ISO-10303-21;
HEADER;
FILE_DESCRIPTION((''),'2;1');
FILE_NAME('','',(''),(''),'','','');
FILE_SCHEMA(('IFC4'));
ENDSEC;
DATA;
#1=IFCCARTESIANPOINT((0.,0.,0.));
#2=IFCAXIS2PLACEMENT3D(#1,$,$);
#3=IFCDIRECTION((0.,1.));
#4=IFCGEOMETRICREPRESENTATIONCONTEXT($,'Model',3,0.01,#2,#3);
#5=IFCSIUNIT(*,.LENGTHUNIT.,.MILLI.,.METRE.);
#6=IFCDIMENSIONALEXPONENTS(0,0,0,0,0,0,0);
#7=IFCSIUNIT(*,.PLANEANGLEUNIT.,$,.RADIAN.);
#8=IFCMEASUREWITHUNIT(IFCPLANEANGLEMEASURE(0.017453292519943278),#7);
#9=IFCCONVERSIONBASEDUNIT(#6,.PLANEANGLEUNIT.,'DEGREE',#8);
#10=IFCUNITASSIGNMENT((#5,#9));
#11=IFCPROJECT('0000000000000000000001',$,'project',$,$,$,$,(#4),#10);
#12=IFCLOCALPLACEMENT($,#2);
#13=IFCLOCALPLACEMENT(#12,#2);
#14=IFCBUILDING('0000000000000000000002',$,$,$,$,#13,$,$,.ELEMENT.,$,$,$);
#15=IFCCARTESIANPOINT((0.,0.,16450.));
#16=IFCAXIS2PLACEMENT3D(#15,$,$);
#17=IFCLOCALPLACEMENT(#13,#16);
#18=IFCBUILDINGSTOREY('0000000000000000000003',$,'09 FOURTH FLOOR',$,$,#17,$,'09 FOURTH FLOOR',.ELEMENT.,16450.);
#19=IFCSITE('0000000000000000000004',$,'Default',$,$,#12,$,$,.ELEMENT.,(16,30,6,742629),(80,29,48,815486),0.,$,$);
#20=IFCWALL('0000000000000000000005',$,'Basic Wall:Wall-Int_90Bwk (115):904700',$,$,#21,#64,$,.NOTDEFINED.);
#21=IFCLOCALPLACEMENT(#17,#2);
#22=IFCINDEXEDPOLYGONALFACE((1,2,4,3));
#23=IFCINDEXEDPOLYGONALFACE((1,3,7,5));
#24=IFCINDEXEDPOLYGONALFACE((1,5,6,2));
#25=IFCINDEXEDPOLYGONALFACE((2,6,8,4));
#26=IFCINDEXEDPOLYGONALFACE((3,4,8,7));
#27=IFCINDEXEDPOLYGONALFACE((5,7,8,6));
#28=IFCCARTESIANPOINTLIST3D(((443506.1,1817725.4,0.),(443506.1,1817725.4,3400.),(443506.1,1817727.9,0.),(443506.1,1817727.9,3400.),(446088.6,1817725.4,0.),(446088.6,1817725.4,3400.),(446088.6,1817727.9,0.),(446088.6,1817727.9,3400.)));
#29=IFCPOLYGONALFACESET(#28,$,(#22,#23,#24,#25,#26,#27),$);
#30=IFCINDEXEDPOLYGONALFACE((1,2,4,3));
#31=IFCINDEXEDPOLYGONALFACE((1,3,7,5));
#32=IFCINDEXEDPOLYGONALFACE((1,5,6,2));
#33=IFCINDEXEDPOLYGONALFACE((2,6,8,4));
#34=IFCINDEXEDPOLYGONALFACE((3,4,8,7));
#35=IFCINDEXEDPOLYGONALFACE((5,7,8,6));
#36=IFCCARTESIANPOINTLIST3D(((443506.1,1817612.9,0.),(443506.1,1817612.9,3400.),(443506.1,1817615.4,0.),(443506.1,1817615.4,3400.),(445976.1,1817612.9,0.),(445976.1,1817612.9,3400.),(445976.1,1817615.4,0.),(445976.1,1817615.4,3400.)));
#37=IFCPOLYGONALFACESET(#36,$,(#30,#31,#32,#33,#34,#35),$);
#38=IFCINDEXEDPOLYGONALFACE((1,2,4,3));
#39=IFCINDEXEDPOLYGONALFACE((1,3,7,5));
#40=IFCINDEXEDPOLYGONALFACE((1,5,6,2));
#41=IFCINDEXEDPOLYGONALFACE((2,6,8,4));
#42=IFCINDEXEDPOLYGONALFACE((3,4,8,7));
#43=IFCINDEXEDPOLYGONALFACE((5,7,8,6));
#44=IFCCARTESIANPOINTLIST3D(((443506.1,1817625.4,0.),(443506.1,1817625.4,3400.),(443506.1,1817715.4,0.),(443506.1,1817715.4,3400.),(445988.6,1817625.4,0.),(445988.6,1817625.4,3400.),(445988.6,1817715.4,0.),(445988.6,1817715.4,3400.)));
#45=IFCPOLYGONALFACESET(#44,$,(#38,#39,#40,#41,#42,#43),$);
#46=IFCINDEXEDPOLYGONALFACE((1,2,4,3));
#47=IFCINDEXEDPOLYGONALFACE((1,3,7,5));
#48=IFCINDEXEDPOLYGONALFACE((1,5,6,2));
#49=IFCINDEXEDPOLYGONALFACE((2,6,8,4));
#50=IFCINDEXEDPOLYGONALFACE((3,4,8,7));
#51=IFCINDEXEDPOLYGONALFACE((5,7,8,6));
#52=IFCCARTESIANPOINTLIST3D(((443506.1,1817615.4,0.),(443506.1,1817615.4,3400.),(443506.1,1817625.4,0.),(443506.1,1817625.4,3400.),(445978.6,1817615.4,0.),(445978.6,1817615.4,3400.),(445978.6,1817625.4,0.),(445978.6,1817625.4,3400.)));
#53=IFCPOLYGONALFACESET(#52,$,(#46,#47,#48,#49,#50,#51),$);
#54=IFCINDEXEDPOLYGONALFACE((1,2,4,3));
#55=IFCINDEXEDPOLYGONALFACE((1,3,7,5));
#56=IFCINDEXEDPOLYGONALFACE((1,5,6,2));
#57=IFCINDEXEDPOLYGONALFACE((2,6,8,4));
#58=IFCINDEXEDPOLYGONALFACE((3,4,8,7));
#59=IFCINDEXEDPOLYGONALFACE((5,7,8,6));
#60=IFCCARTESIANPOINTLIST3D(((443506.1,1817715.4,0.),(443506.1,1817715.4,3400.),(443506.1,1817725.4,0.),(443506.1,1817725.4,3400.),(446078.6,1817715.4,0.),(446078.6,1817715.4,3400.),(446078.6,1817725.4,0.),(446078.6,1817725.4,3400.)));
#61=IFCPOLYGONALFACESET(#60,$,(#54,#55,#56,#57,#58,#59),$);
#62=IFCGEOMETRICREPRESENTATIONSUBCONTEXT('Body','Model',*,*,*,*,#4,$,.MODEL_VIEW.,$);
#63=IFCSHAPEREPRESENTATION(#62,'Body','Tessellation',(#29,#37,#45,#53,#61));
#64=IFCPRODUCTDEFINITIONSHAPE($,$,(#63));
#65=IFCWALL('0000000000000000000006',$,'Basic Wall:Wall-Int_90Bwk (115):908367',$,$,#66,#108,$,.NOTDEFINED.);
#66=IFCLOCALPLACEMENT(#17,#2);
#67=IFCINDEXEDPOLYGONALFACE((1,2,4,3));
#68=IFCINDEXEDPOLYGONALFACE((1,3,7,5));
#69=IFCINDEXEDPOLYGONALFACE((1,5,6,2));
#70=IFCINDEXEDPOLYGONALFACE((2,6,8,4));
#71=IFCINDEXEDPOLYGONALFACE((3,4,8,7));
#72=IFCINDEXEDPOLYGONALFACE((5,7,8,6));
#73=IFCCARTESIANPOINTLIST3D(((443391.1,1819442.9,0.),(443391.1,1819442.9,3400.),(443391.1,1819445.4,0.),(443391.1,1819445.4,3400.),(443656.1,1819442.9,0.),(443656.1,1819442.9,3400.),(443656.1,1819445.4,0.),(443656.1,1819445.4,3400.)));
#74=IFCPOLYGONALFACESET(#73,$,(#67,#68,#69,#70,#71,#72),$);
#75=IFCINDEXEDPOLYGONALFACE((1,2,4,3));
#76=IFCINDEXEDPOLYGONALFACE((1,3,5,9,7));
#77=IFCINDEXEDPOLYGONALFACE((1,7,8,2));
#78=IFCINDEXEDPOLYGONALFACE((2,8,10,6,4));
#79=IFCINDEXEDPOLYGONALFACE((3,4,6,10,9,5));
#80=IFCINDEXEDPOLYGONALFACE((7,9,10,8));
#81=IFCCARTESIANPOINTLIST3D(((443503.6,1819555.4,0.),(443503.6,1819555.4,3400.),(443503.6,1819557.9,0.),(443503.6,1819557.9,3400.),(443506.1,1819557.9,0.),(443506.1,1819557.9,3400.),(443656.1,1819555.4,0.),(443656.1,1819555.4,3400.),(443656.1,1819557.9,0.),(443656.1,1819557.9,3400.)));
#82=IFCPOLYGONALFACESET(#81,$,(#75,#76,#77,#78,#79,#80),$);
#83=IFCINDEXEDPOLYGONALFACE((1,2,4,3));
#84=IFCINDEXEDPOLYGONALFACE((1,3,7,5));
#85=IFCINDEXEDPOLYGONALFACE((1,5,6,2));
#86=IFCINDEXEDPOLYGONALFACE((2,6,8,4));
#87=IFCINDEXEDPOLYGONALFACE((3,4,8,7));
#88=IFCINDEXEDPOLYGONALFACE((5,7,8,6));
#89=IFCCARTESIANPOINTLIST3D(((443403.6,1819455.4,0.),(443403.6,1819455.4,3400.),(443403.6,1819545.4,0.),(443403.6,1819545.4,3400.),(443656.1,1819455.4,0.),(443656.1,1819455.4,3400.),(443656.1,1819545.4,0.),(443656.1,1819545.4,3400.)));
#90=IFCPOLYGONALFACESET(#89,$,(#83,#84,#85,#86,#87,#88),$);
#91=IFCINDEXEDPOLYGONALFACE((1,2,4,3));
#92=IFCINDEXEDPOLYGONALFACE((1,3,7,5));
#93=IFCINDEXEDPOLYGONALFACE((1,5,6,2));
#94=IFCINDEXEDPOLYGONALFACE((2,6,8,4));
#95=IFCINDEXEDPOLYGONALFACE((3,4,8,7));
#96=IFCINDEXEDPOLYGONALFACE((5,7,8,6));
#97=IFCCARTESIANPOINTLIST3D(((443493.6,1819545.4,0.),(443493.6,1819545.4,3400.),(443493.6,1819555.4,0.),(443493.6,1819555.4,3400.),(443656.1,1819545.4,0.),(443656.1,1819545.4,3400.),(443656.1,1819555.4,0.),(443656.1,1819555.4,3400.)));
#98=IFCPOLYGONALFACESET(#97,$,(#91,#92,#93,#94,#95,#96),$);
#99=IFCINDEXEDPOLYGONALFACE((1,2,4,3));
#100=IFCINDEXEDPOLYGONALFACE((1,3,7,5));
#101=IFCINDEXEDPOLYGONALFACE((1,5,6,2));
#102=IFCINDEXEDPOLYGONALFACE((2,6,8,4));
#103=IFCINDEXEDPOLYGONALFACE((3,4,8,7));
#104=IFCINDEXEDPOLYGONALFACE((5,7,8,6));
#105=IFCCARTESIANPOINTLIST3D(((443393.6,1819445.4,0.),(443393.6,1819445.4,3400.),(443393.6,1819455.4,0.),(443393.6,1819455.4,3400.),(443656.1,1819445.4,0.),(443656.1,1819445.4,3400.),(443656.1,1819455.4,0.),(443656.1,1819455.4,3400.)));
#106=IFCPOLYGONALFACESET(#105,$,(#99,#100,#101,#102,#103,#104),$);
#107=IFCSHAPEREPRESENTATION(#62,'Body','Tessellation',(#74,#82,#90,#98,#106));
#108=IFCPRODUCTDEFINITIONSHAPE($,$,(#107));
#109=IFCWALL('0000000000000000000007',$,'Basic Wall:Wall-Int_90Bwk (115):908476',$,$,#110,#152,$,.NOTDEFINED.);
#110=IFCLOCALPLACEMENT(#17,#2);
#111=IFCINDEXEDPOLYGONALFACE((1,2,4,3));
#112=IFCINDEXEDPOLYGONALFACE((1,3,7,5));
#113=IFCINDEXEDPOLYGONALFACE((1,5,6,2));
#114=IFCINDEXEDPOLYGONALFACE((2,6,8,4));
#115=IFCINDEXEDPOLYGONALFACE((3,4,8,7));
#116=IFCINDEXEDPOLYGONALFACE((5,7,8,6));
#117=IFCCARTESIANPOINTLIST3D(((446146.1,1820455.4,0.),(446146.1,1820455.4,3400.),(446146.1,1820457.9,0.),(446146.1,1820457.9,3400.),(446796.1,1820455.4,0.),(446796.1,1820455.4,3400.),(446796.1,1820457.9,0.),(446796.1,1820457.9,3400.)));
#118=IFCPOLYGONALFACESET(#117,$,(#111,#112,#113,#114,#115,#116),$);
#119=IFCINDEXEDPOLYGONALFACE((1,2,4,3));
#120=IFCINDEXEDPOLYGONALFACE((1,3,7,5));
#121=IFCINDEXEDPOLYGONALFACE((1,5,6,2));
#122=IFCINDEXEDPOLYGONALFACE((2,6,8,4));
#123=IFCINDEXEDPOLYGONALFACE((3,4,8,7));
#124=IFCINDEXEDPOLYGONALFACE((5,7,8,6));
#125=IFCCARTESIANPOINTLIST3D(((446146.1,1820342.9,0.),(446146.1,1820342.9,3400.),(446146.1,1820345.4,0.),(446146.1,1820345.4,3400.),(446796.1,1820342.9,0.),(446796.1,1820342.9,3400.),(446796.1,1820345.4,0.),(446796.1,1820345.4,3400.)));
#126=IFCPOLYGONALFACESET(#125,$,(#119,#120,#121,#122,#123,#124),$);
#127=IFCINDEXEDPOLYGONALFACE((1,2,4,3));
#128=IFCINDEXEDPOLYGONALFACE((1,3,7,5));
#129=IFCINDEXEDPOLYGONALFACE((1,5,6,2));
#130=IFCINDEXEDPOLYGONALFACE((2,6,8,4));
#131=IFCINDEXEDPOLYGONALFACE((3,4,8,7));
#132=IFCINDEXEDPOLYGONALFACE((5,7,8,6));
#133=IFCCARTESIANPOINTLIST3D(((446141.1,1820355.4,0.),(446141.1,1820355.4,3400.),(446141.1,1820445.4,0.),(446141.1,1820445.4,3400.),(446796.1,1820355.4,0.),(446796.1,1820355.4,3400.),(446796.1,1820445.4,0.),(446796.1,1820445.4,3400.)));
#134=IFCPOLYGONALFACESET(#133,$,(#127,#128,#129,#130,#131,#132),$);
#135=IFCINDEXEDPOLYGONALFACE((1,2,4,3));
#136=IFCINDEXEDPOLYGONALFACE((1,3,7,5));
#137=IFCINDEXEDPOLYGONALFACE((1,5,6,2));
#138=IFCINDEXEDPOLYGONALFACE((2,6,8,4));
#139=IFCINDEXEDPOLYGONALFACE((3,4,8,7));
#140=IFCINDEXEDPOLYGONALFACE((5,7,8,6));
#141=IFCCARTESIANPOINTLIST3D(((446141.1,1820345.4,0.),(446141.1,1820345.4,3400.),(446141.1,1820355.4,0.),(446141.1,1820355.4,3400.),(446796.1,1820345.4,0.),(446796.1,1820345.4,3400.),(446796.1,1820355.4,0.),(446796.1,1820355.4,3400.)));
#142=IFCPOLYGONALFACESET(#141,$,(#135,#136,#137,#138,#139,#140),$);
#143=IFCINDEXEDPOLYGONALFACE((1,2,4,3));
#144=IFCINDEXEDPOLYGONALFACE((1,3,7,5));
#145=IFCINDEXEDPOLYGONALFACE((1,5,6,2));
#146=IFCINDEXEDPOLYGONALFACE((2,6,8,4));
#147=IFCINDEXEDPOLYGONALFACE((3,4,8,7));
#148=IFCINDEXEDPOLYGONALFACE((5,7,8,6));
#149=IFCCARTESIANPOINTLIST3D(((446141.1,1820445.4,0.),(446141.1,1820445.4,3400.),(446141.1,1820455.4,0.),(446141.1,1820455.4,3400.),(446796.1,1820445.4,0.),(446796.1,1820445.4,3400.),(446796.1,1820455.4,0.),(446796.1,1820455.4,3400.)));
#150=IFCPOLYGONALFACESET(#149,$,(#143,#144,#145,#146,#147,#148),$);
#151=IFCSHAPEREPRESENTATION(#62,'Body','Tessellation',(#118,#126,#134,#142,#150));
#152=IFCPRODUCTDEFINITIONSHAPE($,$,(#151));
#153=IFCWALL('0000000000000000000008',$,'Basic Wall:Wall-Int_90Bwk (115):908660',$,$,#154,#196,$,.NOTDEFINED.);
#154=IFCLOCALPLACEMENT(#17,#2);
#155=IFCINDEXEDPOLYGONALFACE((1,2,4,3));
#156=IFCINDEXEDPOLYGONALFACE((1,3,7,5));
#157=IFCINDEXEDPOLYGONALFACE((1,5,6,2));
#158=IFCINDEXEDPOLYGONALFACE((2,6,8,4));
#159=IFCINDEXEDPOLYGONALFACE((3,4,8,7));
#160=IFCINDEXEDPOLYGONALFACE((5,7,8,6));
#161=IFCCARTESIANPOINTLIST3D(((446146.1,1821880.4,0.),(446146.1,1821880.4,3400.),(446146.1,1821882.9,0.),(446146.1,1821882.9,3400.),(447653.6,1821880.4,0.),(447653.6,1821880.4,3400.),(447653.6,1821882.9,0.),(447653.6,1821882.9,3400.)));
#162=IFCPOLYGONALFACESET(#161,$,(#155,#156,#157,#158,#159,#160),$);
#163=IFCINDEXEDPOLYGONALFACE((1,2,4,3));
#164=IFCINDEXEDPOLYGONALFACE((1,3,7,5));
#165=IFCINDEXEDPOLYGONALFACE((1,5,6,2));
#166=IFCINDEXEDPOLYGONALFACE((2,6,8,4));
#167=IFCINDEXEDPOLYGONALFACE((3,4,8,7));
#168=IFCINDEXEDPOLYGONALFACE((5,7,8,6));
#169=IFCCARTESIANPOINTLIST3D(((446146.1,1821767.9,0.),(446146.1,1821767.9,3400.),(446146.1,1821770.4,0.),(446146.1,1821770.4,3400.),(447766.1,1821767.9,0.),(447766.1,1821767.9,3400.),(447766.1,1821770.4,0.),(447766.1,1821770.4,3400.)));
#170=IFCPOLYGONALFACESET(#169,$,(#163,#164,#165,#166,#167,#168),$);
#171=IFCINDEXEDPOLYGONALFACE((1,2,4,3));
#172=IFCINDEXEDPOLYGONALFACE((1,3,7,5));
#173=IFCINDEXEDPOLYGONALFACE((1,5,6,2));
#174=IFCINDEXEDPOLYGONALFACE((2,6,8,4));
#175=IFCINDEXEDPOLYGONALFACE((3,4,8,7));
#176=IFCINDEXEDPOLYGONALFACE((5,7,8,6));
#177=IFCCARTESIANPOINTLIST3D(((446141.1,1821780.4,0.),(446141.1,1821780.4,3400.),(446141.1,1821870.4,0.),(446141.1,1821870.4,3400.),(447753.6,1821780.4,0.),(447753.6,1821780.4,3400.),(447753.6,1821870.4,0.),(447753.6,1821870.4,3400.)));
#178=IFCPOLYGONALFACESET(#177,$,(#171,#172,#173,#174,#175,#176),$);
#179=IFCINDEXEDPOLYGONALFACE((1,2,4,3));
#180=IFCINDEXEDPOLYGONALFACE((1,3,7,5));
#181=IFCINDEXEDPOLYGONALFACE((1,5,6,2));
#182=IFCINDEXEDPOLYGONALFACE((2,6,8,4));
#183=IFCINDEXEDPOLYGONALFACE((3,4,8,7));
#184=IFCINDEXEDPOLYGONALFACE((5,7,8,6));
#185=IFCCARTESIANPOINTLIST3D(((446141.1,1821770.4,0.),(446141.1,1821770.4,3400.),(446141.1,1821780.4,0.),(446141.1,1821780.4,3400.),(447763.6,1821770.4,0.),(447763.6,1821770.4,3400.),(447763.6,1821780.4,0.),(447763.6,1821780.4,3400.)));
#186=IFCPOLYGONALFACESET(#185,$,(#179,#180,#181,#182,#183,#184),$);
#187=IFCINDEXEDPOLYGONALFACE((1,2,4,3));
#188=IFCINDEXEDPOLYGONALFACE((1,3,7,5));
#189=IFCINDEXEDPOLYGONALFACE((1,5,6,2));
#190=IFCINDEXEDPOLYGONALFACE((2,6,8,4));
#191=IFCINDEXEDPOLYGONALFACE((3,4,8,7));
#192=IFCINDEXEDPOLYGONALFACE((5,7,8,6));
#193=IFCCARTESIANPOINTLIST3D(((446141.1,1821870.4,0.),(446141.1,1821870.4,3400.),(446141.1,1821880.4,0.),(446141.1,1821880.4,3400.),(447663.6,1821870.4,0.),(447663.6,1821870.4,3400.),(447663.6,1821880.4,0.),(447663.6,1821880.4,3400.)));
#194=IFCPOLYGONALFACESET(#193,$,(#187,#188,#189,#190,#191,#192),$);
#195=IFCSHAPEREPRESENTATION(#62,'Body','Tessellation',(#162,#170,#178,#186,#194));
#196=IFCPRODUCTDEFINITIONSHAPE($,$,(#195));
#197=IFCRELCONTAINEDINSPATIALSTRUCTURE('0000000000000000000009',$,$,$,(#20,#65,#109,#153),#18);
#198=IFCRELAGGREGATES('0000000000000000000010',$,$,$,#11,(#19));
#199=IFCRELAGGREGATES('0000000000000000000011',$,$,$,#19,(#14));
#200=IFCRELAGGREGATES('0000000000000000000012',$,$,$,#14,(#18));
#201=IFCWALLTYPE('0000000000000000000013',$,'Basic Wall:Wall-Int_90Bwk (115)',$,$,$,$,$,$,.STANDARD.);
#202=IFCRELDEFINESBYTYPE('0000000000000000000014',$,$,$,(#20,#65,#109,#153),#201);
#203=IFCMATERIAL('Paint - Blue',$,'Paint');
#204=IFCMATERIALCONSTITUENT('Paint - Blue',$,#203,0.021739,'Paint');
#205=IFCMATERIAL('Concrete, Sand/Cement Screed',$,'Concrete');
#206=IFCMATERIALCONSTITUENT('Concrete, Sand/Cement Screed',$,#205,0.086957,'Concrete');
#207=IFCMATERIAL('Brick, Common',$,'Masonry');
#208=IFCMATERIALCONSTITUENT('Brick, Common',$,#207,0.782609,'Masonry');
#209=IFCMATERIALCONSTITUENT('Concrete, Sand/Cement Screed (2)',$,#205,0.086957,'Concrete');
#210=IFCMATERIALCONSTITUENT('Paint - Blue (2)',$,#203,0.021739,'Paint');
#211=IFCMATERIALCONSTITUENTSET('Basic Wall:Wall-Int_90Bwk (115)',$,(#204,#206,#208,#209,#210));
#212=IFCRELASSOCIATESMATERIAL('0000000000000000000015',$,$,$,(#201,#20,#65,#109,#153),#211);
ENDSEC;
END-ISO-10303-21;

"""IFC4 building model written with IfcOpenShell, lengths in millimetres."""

from ifc_helpers import new_model, entity, si_unit, converted_unit, direction, frame, origin, place, context, subcontext, project, spatial, indexed_curve, outline, extrude, material, constituent, constituent_set, type_object, element, save


model = new_model("IFC4")

# Units and contexts
model_context = context("Model", 3, precision=0.01, world=origin(), true_north=direction((0.0, 1.0)))
body_context = subcontext(model_context, "Body", "Model", "MODEL_VIEW")
ifc_project = project(units=[si_unit("LENGTHUNIT", "METRE", prefix="MILLI"), converted_unit("PLANEANGLEUNIT", "DEGREE", entity("IfcPlaneAngleMeasure", 0.017453292519943278), si_unit("PLANEANGLEUNIT", "RADIAN"), dimensions=[0, 0, 0, 0, 0, 0, 0])], contexts=[model_context])

# Site, building, storey
site_placement = place(None, origin())
site = spatial("IfcSite", under=ifc_project, at=site_placement, Name="Default", CompositionType="ELEMENT", RefLatitude=(16, 30, 6, 742629), RefLongitude=(80, 29, 48, 815486), RefElevation=0.0)
building_placement = place(site_placement, origin())
building = spatial("IfcBuilding", under=site, at=building_placement, CompositionType="ELEMENT")
storey_placement = place(building_placement, frame((0.0, 0.0, 16450.0)))
storey = spatial("IfcBuildingStorey", under=building, at=storey_placement, Name="09 FOURTH FLOOR", LongName="09 FOURTH FLOOR", CompositionType="ELEMENT", Elevation=16450.0)

# Wall
ifc_material_1 = material(Name="Paint - Blue", Category="Paint")
ifc_constituent_1 = constituent(ifc_material_1, Name="Paint - Blue", Category="Paint", fraction=0.021739)
ifc_material_2 = material(Name="Concrete, Sand/Cement Screed", Category="Concrete")
ifc_constituent_2 = constituent(ifc_material_2, Name="Concrete, Sand/Cement Screed", Category="Concrete", fraction=0.086957)
ifc_material_3 = material(Name="Brick, Common", Category="Masonry")
ifc_constituent_3 = constituent(ifc_material_3, Name="Brick, Common", Category="Masonry", fraction=0.782609)
ifc_constituent_4 = constituent(ifc_material_2, Name="Concrete, Sand/Cement Screed (2)", Category="Concrete", fraction=0.086957)
ifc_constituent_5 = constituent(ifc_material_1, Name="Paint - Blue (2)", Category="Paint", fraction=0.021739)
ifc_constituent_set_1 = constituent_set(constituents=[ifc_constituent_1, ifc_constituent_2, ifc_constituent_3, ifc_constituent_4, ifc_constituent_5], Name="Basic Wall:Wall-Int_90Bwk (115)")
wall_type_1 = type_object("IfcWallType", Name="Basic Wall:Wall-Int_90Bwk (115)", PredefinedType="STANDARD", material=ifc_constituent_set_1)
wall_1_placement = place(storey_placement, frame((445976.1, 1817670.4, 0.0), z_axis=(0.0, 0.0, 1.0), x_axis=(-1.0, 0.0, 0.0)))
element("IfcWall", 1, at=wall_1_placement, inside=storey, type_object=wall_type_1, material=ifc_constituent_set_1, Name="Basic Wall:Wall-Int_90Bwk (115):904700", PredefinedType="NOTDEFINED", context=body_context, shape_type="SweptSolid", body=[
    extrude(outline(indexed_curve([(-1.2, -1291.2), (1.3, -1291.2), (1.3, 1291.2), (-1.2, 1291.2), (-1.2, -1291.2)], self_intersect=False)), frame((1178.7, -56.3, 0.0), z_axis=(0.0, 0.0, 1.0), x_axis=(0.0, 1.0, 0.0)), (0.0, 0.0, 1.0), 3400.0),
    extrude(outline(indexed_curve([(-1.3, -1235.0), (1.3, -1235.0), (1.3, 1235.0), (-1.3, 1235.0), (-1.3, -1235.0)], self_intersect=False)), frame((1235.0, 56.3, 0.0), z_axis=(0.0, 0.0, 1.0), x_axis=(0.0, -1.0, 0.0)), (0.0, 0.0, 1.0), 3400.0),
    extrude(outline(indexed_curve([(-1241.2, -45.0), (1241.2, -45.0), (1241.2, 45.0), (-1241.2, 45.0), (-1241.2, -45.0)], self_intersect=False)), frame((1228.7, 0.0, 0.0)), (0.0, 0.0, 1.0), 3400.0),
    extrude(outline(indexed_curve([(-1236.2, -5.0), (1236.2, -5.0), (1236.2, 5.0), (-1236.2, 5.0), (-1236.2, -5.0)], self_intersect=False)), frame((1233.7, 50.0, 0.0)), (0.0, 0.0, 1.0), 3400.0),
    extrude(outline(indexed_curve([(-1286.2, -5.0), (1286.2, -5.0), (1286.2, 5.0), (-1286.2, 5.0), (-1286.2, -5.0)], self_intersect=False)), frame((1183.7, -50.0, 0.0)), (0.0, 0.0, 1.0), 3400.0),
])

# Walls
wall_2_placement = place(storey_placement, frame((443391.1, 1819500.4, 0.0)))
element("IfcWall", 2, at=wall_2_placement, inside=storey, type_object=wall_type_1, material=ifc_constituent_set_1, Name="Basic Wall:Wall-Int_90Bwk (115):908367", PredefinedType="NOTDEFINED", context=body_context, shape_type="SweptSolid", body=[
    extrude(outline(indexed_curve([(-1.2, -132.5), (1.3, -132.5), (1.3, 132.5), (-1.2, 132.5), (-1.2, -132.5)], self_intersect=False)), frame((132.5, -56.3, 0.0), z_axis=(0.0, 0.0, 1.0), x_axis=(0.0, 1.0, 0.0)), (0.0, 0.0, 1.0), 3400.0),
    extrude(outline(indexed_curve([(59.0, -1.0), (61.5, -1.0), (61.5, 1.5), (-91.0, 1.5), (-91.0, -1.0), (59.0, -1.0)], self_intersect=False)), frame((174.0, 56.5, 0.0), z_axis=(0.0, 0.0, 1.0), x_axis=(-1.0, 0.0, 0.0)), (0.0, 0.0, 1.0), 3400.0),
    extrude(outline(indexed_curve([(-126.3, -45.0), (126.2, -45.0), (126.2, 45.0), (-126.3, 45.0), (-126.3, -45.0)], self_intersect=False)), frame((138.8, 0.0, 0.0)), (0.0, 0.0, 1.0), 3400.0),
    extrude(outline(indexed_curve([(-81.3, -5.0), (81.3, -5.0), (81.3, 5.0), (-81.3, 5.0), (-81.3, -5.0)], self_intersect=False)), frame((183.8, 50.0, 0.0)), (0.0, 0.0, 1.0), 3400.0),
    extrude(outline(indexed_curve([(-131.2, -5.0), (131.3, -5.0), (131.3, 5.0), (-131.2, 5.0), (-131.2, -5.0)], self_intersect=False)), frame((133.8, -50.0, 0.0)), (0.0, 0.0, 1.0), 3400.0),
])
wall_3_placement = place(storey_placement, frame((446146.1, 1820400.4, 0.0)))
element("IfcWall", 3, at=wall_3_placement, inside=storey, type_object=wall_type_1, material=ifc_constituent_set_1, Name="Basic Wall:Wall-Int_90Bwk (115):908476", PredefinedType="NOTDEFINED", context=body_context, shape_type="SweptSolid", body=[
    extrude(outline(indexed_curve([(-1.3, -325.0), (1.2, -325.0), (1.2, 325.0), (-1.3, 325.0), (-1.3, -325.0)], self_intersect=False)), frame((325.0, 56.2, 0.0), z_axis=(0.0, 0.0, 1.0), x_axis=(0.0, -1.0, 0.0)), (0.0, 0.0, 1.0), 3400.0),
    extrude(outline(indexed_curve([(-1.3, -325.0), (1.2, -325.0), (1.2, 325.0), (-1.3, 325.0), (-1.3, -325.0)], self_intersect=False)), frame((325.0, -56.2, 0.0), z_axis=(0.0, 0.0, 1.0), x_axis=(0.0, 1.0, 0.0)), (0.0, 0.0, 1.0), 3400.0),
    extrude(outline(indexed_curve([(-327.5, -45.0), (327.5, -45.0), (327.5, 45.0), (-327.5, 45.0), (-327.5, -45.0)], self_intersect=False)), frame((322.5, 0.0, 0.0)), (0.0, 0.0, 1.0), 3400.0),
    extrude(outline(indexed_curve([(-327.5, -5.0), (327.5, -5.0), (327.5, 5.0), (-327.5, 5.0), (-327.5, -5.0)], self_intersect=False)), frame((322.5, -50.0, 0.0)), (0.0, 0.0, 1.0), 3400.0),
    extrude(outline(indexed_curve([(-327.5, -5.0), (327.5, -5.0), (327.5, 5.0), (-327.5, 5.0), (-327.5, -5.0)], self_intersect=False)), frame((322.5, 50.0, 0.0)), (0.0, 0.0, 1.0), 3400.0),
])

# Wall, opening
wall_4_placement = place(storey_placement, frame((446146.1, 1821825.4, 0.0)))
wall_4 = element("IfcWall", 4, at=wall_4_placement, inside=storey, type_object=wall_type_1, material=ifc_constituent_set_1, Name="Basic Wall:Wall-Int_90Bwk (115):908660", PredefinedType="NOTDEFINED", context=body_context, shape_type="SweptSolid", body=[
    extrude(outline(indexed_curve([(-1.3, -753.7), (1.3, -753.7), (1.3, 753.7), (-1.3, 753.7), (-1.3, -753.7)], self_intersect=False)), frame((753.7, 56.3, 0.0), z_axis=(0.0, 0.0, 1.0), x_axis=(0.0, -1.0, 0.0)), (0.0, 0.0, 1.0), 3400.0),
    extrude(outline(indexed_curve([(-1.2, -810.0), (1.3, -810.0), (1.3, 810.0), (-1.2, 810.0), (-1.2, -810.0)], self_intersect=False)), frame((810.0, -56.3, 0.0), z_axis=(0.0, 0.0, 1.0), x_axis=(0.0, 1.0, 0.0)), (0.0, 0.0, 1.0), 3400.0),
    extrude(outline(indexed_curve([(-806.2, -45.0), (806.3, -45.0), (806.3, 45.0), (-806.2, 45.0), (-806.2, -45.0)], self_intersect=False)), frame((801.2, 0.0, 0.0)), (0.0, 0.0, 1.0), 3400.0),
    extrude(outline(indexed_curve([(-811.3, -5.0), (811.2, -5.0), (811.2, 5.0), (-811.3, 5.0), (-811.3, -5.0)], self_intersect=False)), frame((806.3, -50.0, 0.0)), (0.0, 0.0, 1.0), 3400.0),
    extrude(outline(indexed_curve([(-761.3, -5.0), (761.2, -5.0), (761.2, 5.0), (-761.3, 5.0), (-761.3, -5.0)], self_intersect=False)), frame((756.3, 50.0, 0.0)), (0.0, 0.0, 1.0), 3400.0),
])
opening_1_placement = place(wall_4_placement, origin())
element("IfcOpeningElement", 5, at=opening_1_placement, cuts=wall_4, PredefinedType="OPENING", context=body_context, shape_type="SweptSolid", body=[
    extrude(outline(indexed_curve([(-57.5, -1050.0), (57.5, -1050.0), (57.5, 1050.0), (-57.5, 1050.0), (-57.5, -1050.0)], self_intersect=False)), frame((1562.5, 57.5, 1050.0), z_axis=(0.0, 1.0, 0.0), x_axis=(-1.0, 0.0, 0.0)), (0.0, 0.0, 1.0), 800.0),
])

save(model, "model.ifc")
